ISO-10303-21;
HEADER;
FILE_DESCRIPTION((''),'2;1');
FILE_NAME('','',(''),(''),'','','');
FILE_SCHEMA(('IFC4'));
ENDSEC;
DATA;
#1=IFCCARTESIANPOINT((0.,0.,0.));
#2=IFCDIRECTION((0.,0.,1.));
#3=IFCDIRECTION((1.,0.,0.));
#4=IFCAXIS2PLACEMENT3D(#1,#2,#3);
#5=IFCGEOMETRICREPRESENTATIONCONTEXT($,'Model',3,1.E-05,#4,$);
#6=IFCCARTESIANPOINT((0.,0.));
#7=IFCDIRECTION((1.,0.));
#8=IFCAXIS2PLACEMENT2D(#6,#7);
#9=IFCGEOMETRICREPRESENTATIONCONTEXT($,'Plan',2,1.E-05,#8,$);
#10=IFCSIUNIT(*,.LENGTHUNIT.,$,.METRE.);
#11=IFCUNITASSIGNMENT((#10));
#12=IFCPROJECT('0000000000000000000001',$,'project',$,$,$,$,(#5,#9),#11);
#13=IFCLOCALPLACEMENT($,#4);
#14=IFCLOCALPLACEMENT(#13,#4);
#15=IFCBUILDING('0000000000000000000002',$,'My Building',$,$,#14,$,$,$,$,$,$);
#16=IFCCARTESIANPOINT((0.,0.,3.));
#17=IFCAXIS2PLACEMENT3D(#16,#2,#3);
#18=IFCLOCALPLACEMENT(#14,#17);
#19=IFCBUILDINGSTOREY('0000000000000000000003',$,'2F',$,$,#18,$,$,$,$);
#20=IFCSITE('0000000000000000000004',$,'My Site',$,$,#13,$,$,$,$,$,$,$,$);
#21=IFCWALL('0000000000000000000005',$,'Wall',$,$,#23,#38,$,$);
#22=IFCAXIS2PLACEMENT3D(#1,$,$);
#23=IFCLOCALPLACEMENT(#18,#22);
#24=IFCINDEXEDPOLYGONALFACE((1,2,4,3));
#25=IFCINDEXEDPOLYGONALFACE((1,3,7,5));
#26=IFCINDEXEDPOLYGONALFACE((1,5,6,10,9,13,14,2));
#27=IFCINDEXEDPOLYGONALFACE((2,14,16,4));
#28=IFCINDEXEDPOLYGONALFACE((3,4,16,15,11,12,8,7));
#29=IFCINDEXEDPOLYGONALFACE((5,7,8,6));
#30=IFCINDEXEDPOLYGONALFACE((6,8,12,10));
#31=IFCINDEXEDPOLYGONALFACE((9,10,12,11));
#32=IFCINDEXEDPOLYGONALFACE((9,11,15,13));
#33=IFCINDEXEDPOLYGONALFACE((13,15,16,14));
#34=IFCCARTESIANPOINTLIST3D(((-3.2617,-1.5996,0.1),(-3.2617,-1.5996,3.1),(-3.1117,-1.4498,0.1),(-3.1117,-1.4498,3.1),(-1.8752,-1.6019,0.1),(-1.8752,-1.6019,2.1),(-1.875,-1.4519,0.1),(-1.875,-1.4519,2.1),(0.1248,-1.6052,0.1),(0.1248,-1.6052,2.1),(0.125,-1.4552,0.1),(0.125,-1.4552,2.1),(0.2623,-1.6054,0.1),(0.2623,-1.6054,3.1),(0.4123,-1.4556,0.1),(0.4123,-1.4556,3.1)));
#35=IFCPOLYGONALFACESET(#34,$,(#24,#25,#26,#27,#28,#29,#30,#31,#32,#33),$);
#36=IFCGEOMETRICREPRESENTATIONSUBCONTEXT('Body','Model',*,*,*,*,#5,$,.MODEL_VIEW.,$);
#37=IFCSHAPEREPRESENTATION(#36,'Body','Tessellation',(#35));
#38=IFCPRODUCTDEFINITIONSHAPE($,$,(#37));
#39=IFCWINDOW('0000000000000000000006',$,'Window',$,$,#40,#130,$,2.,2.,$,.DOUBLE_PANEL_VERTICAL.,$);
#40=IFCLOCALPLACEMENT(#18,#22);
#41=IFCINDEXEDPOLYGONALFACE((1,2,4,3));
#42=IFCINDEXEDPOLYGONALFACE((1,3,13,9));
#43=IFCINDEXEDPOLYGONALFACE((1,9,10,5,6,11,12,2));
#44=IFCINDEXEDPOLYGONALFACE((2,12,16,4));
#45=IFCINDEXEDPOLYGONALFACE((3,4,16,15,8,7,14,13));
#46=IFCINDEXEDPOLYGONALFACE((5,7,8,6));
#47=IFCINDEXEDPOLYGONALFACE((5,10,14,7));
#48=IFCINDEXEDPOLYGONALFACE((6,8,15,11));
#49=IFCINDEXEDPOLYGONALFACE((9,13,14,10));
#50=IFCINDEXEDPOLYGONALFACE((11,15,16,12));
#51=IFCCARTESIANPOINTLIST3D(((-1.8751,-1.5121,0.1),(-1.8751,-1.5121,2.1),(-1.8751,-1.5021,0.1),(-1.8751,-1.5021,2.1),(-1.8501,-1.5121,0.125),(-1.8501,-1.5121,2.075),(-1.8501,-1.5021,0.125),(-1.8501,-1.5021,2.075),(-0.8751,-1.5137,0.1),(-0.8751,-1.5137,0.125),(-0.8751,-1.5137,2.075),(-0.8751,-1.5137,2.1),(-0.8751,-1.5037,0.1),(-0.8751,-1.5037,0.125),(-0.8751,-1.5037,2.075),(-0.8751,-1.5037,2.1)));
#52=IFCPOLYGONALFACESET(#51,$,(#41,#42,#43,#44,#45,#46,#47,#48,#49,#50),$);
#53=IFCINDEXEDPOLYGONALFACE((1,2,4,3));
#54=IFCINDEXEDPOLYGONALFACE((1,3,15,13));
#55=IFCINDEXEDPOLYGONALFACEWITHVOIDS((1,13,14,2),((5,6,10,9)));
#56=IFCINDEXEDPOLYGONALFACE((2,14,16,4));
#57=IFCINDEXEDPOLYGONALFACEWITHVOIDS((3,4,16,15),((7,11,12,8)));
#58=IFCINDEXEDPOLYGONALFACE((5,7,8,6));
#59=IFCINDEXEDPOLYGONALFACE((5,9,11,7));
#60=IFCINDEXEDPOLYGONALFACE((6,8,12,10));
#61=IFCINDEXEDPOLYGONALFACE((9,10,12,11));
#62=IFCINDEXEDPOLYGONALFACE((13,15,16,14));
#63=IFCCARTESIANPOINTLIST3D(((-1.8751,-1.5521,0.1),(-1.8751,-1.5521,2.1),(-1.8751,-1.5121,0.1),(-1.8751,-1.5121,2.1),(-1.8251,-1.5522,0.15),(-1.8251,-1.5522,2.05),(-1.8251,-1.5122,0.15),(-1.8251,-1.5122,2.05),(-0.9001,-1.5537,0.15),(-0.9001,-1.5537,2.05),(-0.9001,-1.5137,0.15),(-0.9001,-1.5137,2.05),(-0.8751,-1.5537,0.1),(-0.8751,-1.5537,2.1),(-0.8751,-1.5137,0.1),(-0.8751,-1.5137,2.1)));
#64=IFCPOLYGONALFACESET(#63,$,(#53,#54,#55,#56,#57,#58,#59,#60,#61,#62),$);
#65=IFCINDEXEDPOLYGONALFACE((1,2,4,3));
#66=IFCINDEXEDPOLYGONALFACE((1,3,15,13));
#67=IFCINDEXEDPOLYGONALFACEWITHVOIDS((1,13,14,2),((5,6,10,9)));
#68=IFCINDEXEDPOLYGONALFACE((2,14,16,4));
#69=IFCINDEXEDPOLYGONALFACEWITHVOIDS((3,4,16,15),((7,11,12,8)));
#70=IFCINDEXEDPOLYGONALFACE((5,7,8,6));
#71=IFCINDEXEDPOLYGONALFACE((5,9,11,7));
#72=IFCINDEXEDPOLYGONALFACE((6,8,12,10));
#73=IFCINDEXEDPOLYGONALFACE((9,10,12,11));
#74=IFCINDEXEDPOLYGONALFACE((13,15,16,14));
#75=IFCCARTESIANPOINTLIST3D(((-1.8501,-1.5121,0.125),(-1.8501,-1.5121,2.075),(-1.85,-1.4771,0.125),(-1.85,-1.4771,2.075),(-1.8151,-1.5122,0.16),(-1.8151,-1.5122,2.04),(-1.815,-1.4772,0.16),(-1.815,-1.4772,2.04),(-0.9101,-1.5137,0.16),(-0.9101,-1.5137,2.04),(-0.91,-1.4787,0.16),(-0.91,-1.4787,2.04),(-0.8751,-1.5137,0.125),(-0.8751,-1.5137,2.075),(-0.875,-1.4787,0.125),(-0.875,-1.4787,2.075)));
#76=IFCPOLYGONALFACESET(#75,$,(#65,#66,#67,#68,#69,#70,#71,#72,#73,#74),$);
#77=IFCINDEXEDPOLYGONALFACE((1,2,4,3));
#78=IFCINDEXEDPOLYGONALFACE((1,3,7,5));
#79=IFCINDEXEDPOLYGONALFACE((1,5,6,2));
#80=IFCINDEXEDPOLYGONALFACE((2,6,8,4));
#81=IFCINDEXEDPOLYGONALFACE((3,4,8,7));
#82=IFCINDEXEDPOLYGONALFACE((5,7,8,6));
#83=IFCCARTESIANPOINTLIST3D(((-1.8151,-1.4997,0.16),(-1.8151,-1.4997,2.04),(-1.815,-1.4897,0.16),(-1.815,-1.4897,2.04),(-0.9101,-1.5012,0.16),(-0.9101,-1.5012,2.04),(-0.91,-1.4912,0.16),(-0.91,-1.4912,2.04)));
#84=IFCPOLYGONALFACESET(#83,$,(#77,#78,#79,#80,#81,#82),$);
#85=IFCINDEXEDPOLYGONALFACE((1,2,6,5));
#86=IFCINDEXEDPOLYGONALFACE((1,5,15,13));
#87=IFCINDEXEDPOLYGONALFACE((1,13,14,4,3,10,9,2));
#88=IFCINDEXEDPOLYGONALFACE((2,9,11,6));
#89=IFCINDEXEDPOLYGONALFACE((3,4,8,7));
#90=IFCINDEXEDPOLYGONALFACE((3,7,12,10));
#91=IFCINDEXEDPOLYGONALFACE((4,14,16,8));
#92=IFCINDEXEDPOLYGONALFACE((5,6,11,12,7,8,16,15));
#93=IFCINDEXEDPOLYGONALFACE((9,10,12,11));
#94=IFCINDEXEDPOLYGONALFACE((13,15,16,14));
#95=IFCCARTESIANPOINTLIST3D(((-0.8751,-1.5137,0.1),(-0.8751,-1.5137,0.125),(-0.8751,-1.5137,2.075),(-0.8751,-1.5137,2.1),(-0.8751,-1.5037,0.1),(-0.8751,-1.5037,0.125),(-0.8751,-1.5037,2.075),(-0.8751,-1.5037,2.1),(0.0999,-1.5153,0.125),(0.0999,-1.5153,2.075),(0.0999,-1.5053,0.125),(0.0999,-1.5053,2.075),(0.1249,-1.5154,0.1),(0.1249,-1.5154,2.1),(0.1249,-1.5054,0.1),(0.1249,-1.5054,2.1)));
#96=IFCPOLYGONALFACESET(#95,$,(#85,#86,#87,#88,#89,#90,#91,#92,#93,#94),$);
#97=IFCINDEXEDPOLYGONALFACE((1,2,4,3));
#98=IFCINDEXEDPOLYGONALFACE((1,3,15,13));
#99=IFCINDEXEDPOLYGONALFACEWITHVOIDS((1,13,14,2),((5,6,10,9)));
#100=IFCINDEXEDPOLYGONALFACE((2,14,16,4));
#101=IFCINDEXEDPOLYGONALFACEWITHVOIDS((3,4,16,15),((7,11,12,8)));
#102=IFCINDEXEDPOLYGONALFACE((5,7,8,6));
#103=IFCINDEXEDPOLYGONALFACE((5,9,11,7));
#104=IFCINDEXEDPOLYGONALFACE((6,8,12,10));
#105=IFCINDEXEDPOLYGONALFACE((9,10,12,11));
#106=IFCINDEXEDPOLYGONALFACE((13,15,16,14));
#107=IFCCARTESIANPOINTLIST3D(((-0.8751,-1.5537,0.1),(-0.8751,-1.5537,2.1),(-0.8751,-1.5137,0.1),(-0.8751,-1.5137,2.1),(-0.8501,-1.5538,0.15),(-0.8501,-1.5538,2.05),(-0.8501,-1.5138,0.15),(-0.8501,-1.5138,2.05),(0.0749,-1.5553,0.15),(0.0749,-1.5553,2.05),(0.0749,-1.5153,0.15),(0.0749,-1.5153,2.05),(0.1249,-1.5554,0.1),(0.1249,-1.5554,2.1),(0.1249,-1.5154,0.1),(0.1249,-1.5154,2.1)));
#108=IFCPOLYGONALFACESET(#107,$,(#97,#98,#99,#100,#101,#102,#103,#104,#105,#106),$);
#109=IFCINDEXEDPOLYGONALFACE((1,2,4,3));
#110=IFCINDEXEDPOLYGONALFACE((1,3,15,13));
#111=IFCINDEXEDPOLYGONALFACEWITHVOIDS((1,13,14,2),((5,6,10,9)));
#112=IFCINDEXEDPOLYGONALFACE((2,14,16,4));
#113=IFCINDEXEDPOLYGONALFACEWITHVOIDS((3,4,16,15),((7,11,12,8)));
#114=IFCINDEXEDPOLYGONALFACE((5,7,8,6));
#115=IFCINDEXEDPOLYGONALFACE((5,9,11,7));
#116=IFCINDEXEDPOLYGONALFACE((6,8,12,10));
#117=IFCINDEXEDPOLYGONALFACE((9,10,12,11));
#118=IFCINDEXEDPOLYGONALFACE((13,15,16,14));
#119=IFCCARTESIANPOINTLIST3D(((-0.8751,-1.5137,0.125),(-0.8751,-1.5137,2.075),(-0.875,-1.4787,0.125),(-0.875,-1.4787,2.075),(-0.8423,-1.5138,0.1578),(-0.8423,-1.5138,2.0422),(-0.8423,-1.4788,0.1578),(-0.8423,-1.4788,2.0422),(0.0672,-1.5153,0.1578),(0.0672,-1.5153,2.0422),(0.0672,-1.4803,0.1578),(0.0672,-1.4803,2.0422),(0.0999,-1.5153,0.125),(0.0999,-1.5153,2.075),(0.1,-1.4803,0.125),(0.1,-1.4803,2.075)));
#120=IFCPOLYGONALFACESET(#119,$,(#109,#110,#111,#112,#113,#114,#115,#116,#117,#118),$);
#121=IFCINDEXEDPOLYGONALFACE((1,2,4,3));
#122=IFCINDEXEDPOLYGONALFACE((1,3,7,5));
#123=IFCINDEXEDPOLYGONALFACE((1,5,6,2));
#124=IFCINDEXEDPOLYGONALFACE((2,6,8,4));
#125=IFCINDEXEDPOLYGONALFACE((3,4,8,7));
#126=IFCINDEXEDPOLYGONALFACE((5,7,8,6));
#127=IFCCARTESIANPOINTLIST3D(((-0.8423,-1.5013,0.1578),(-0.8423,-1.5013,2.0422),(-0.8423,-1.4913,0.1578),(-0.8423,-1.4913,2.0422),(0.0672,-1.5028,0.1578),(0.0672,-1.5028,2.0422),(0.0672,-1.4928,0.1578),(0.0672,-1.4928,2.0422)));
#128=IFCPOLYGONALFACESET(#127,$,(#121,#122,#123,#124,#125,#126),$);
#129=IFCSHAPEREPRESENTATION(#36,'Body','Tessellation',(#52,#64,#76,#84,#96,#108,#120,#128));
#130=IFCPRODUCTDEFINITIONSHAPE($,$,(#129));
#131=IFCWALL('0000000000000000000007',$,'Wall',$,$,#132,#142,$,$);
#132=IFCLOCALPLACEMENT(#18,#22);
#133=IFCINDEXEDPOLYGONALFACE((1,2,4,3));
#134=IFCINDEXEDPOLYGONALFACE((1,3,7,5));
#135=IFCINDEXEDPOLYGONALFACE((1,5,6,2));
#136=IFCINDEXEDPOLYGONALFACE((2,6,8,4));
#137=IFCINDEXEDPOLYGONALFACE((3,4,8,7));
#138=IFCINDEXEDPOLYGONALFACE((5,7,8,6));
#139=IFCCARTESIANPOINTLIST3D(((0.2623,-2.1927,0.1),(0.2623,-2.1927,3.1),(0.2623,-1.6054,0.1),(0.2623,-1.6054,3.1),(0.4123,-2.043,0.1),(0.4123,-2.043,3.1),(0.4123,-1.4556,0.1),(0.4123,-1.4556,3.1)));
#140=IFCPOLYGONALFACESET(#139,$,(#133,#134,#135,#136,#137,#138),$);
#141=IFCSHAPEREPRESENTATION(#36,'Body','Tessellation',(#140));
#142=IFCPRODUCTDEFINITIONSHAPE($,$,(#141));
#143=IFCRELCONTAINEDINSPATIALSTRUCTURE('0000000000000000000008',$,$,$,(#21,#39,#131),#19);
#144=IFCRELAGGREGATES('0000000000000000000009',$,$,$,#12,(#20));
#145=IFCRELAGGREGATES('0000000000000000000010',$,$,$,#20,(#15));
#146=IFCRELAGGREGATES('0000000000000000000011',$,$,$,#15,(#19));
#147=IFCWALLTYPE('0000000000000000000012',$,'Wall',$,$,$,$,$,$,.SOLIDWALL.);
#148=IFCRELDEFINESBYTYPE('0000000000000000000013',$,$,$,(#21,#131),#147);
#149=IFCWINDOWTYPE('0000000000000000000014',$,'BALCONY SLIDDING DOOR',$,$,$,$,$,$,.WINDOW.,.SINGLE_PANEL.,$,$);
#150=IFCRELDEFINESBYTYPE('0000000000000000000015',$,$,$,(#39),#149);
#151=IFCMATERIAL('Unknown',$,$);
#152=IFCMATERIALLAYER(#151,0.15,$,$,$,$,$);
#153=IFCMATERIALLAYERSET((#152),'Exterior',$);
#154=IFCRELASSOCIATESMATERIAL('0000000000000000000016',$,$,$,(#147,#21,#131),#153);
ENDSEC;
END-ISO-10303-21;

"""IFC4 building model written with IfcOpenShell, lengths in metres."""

from ifc_helpers import new_model, entity, si_unit, frame, origin_with_axes, origin_2d_with_axis, place, context, subcontext, project, spatial, line, indexed_curve, outline, extrude, shape, source, transform, mapped, material, layer, layer_set, layer_usage, type_object, type_shapes, element, fill, save


model = new_model("IFC4")

# Units and contexts
model_context = context("Model", 3, precision=1e-05, world=origin_with_axes())
plan_context = context("Plan", 2, precision=1e-05, world=origin_2d_with_axis())
body_context_1 = subcontext(model_context, "Body", "Model", "MODEL_VIEW")
body_context_2 = subcontext(plan_context, "Body", "Plan", "PLAN_VIEW")
ifc_project = project(units=[si_unit("LENGTHUNIT", "METRE")], contexts=[model_context, plan_context])

# Site, building, storey
site_placement = place(None, origin_with_axes())
site = spatial("IfcSite", under=ifc_project, at=site_placement, Name="My Site")
building_placement = place(site_placement, origin_with_axes())
building = spatial("IfcBuilding", under=site, at=building_placement, Name="My Building")
storey_placement = place(building_placement, frame((0.0, 0.0, 3.0), z_axis=(0.0, 0.0, 1.0), x_axis=(1.0, 0.0, 0.0)))
storey = spatial("IfcBuildingStorey", under=building, at=storey_placement, Name="2F")

# Shared definitions
ifc_material = material(Name="Unknown")

# Shared definitions
ifc_layer_1 = layer(ifc_material, 0.15)
ifc_layer_set_1 = layer_set([ifc_layer_1], Name="Exterior")
wall_type_1 = type_object("IfcWallType", Name="Wall", PredefinedType="SOLIDWALL", material=ifc_layer_set_1)

# Wall, opening, window
ifc_layer_usage_1 = layer_usage(ifc_layer_set_1, "AXIS2", "POSITIVE", 0.0)
wall_1_placement = place(storey_placement, frame((-3.2617, -1.5996, 0.1), z_axis=(0.0, 0.0, 1.0), x_axis=(0.999999, -0.00165, 0.0)))
wall_1 = element("IfcWall", 1, at=wall_1_placement, inside=storey, type_object=wall_type_1, material=ifc_layer_usage_1, Name="Wall", context=body_context_1, shape_type="SweptSolid", body=[
    extrude(outline(indexed_curve([(0.0, 0.0), (0.1498, 0.15), (3.6737, 0.15), (3.5239, 0.0)], segments=[line(1, 2, 3, 4, 1)])), origin_with_axes(), (0.0, 0.0, 1.0), 3.0),
])
shared_shape_1 = source(origin_with_axes(), body_context_1, "Body", "SweptSolid", [
    extrude(outline(indexed_curve([(0.0, 0.0), (2.0, 0.0), (2.0, 2.0), (0.0, 2.0)], segments=[line(1, 2, 3, 4, 1)])), frame((0.0, -0.6, 0.0), z_axis=(0.0, -1.0, 0.0), x_axis=(1.0, 0.0, 0.0)), (0.0, 0.0, -1.0), 1.2),
])
opening_1_placement = place(wall_1_placement, frame((1.3864, -0.0002, 0.0), z_axis=(0.0, 0.0, 1.0), x_axis=(1.0, 0.0, 0.0)))
opening_1 = element("IfcOpeningElement", 2, at=opening_1_placement, cuts=wall_1, PredefinedType="OPENING", context=body_context_1, shape_type="MappedRepresentation", body=[
    mapped(shared_shape_1, transform((0.0, 0.0, 0.0), x_axis=(1.0, 0.0, 0.0), y_axis=(0.0, 1.0, 0.0), z_axis=(0.0, 0.0, 1.0), scale=1.0)),
])
window_type_1 = type_object("IfcWindowType", Name="BALCONY SLIDDING DOOR", PartitioningType="SINGLE_PANEL", PredefinedType="WINDOW")
shared_shape_2 = source(origin_with_axes(), body_context_1, "Body", "SweptSolid", [
    extrude(outline(indexed_curve([(1.0, 0.0), (0.0, 0.0), (0.0, 2.0), (1.0, 2.0), (1.0, 1.975), (0.025, 1.975), (0.025, 0.025), (1.0, 0.025)], segments=[line(1, 2, 3, 4, 5, 6, 7, 8, 1)])), frame((0.0, 0.09, 0.0), z_axis=(0.0, -1.0, 0.0), x_axis=(1.0, 0.0, 0.0)), (0.0, 0.0, -1.0), 0.01),
    extrude(outline(indexed_curve([(0.0, 0.0), (1.0, 0.0), (1.0, 2.0), (0.0, 2.0)], segments=[line(1, 2, 3, 4, 1)]), holes=[indexed_curve([(0.05, 0.05), (0.975, 0.05), (0.975, 1.95), (0.05, 1.95)], segments=[line(1, 2, 3, 4, 1)])]), frame((0.0, 0.05, 0.0), z_axis=(0.0, -1.0, 0.0), x_axis=(1.0, 0.0, 0.0)), (0.0, 0.0, -1.0), 0.04),
    extrude(outline(indexed_curve([(0.0, 0.0), (0.975, 0.0), (0.975, 1.95), (0.0, 1.95)], segments=[line(1, 2, 3, 4, 1)]), holes=[indexed_curve([(0.035, 0.035), (0.94, 0.035), (0.94, 1.915), (0.035, 1.915)], segments=[line(1, 2, 3, 4, 1)])]), frame((0.025, 0.09, 0.025), z_axis=(0.0, -1.0, 0.0), x_axis=(1.0, 0.0, 0.0)), (0.0, 0.0, -1.0), 0.035),
    extrude(outline(indexed_curve([(0.035, 0.035), (0.94, 0.035), (0.94, 1.915), (0.035, 1.915)], segments=[line(1, 2, 3, 4, 1)])), frame((0.025, 0.1025, 0.025), z_axis=(0.0, -1.0, 0.0), x_axis=(1.0, 0.0, 0.0)), (0.0, 0.0, -1.0), 0.01),
    extrude(outline(indexed_curve([(0.0, 2.0), (1.0, 2.0), (1.0, 0.0), (0.0, 0.0), (0.0, 0.025), (0.975, 0.025), (0.975, 1.975), (0.0, 1.975)], segments=[line(1, 2, 3, 4, 5, 6, 7, 8, 1)])), frame((1.0, 0.09, 0.0), z_axis=(0.0, -1.0, 0.0), x_axis=(1.0, 0.0, 0.0)), (0.0, 0.0, -1.0), 0.01),
    extrude(outline(indexed_curve([(0.0, 0.0), (1.0, 0.0), (1.0, 2.0), (0.0, 2.0)], segments=[line(1, 2, 3, 4, 1)]), holes=[indexed_curve([(0.025, 0.05), (0.95, 0.05), (0.95, 1.95), (0.025, 1.95)], segments=[line(1, 2, 3, 4, 1)])]), frame((1.0, 0.05, 0.0), z_axis=(0.0, -1.0, 0.0), x_axis=(1.0, 0.0, 0.0)), (0.0, 0.0, -1.0), 0.04),
    extrude(outline(indexed_curve([(0.0, 0.0), (0.975, 0.0), (0.975, 1.95), (0.0, 1.95)], segments=[line(1, 2, 3, 4, 1)]), holes=[indexed_curve([(0.0328, 0.0328), (0.9422, 0.0328), (0.9422, 1.9172), (0.0328, 1.9172)], segments=[line(1, 2, 3, 4, 1)])]), frame((1.0, 0.09, 0.025), z_axis=(0.0, -1.0, 0.0), x_axis=(1.0, 0.0, 0.0)), (0.0, 0.0, -1.0), 0.035),
    extrude(outline(indexed_curve([(0.0328, 0.0328), (0.9422, 0.0328), (0.9422, 1.9172), (0.0328, 1.9172)], segments=[line(1, 2, 3, 4, 1)])), frame((1.0, 0.1025, 0.025), z_axis=(0.0, -1.0, 0.0), x_axis=(1.0, 0.0, 0.0)), (0.0, 0.0, -1.0), 0.01),
])
shared_shape_3 = source(origin_with_axes(), body_context_2, "Body", "Curve2D", [
    entity("IfcIndexedPolyCurve", entity("IfcCartesianPointList2D", [[0.05, 0.05], [0.975, 0.05]])),
    entity("IfcIndexedPolyCurve", entity("IfcCartesianPointList2D", [[0.0, 0.1], [0.025, 0.1], [0.025, 0.09], [0.05, 0.09], [0.05, 0.05], [0.0, 0.05]]), [entity("IfcLineIndex", [1, 2, 3, 4, 5, 6, 1])]),
    entity("IfcIndexedPolyCurve", entity("IfcCartesianPointList2D", [[1.0, 0.1], [1.0, 0.1], [1.0, 0.09], [0.975, 0.09], [0.975, 0.05], [1.0, 0.05]])),
    entity("IfcIndexedPolyCurve", entity("IfcCartesianPointList2D", [[0.025, 0.09], [0.06, 0.09], [0.06, 0.125], [0.025, 0.125]]), [entity("IfcLineIndex", [1, 2, 3, 4, 1])]),
    entity("IfcIndexedPolyCurve", entity("IfcCartesianPointList2D", [[1.0, 0.09], [0.965, 0.09], [0.965, 0.125], [1.0, 0.125]]), [entity("IfcLineIndex", [1, 2, 3, 4, 1])]),
    entity("IfcIndexedPolyCurve", entity("IfcCartesianPointList2D", [[0.06, 0.09], [0.965, 0.09]])),
    entity("IfcIndexedPolyCurve", entity("IfcCartesianPointList2D", [[0.06, 0.125], [0.965, 0.125]])),
    entity("IfcIndexedPolyCurve", entity("IfcCartesianPointList2D", [[0.06, 0.1075], [0.965, 0.1075]])),
    entity("IfcIndexedPolyCurve", entity("IfcCartesianPointList2D", [[1.025, 0.05], [1.95, 0.05]])),
    entity("IfcIndexedPolyCurve", entity("IfcCartesianPointList2D", [[1.0, 0.1], [1.0, 0.1], [1.0, 0.09], [1.025, 0.09], [1.025, 0.05], [1.0, 0.05]])),
    entity("IfcIndexedPolyCurve", entity("IfcCartesianPointList2D", [[2.0, 0.1], [1.975, 0.1], [1.975, 0.09], [1.95, 0.09], [1.95, 0.05], [2.0, 0.05]]), [entity("IfcLineIndex", [1, 2, 3, 4, 5, 6, 1])]),
    entity("IfcIndexedPolyCurve", entity("IfcCartesianPointList2D", [[1.0, 0.09], [1.0328, 0.09], [1.0328, 0.125], [1.0, 0.125]]), [entity("IfcLineIndex", [1, 2, 3, 4, 1])]),
    entity("IfcIndexedPolyCurve", entity("IfcCartesianPointList2D", [[1.975, 0.09], [1.9422, 0.09], [1.9422, 0.125], [1.975, 0.125]]), [entity("IfcLineIndex", [1, 2, 3, 4, 1])]),
    entity("IfcIndexedPolyCurve", entity("IfcCartesianPointList2D", [[1.0328, 0.09], [1.9422, 0.09]])),
    entity("IfcIndexedPolyCurve", entity("IfcCartesianPointList2D", [[1.0328, 0.125], [1.9422, 0.125]])),
    entity("IfcIndexedPolyCurve", entity("IfcCartesianPointList2D", [[1.0328, 0.1075], [1.9422, 0.1075]])),
])
type_shapes(window_type_1, [shared_shape_2, shared_shape_3])
window_1_placement = place(opening_1_placement, frame((0.0, 0.0, 0.0), z_axis=(0.0, 0.0, 1.0), x_axis=(1.0, 0.0, 0.0)))
window_1 = element("IfcWindow", 3, at=window_1_placement, inside=storey, type_object=window_type_1, Name="Window", OverallHeight=2.0, OverallWidth=2.0, PartitioningType="DOUBLE_PANEL_VERTICAL", shapes=[
    shape(body_context_1, "Body", "MappedRepresentation", [mapped(shared_shape_2, transform((0.0, 0.0, 0.0), x_axis=(1.0, 0.0, 0.0), y_axis=(0.0, 1.0, 0.0), z_axis=(0.0, 0.0, 1.0), scale=1.0))]),
    shape(body_context_2, "Body", "MappedRepresentation", [mapped(shared_shape_3, transform((0.0, 0.0, 0.0), x_axis=(1.0, 0.0, 0.0), y_axis=(0.0, 1.0, 0.0), z_axis=(0.0, 0.0, 1.0), scale=1.0))]),
])
fill(opening_1, window_1)

# Wall
ifc_layer_usage_2 = layer_usage(ifc_layer_set_1, "AXIS2", "POSITIVE", 0.0)
wall_2_placement = place(storey_placement, frame((0.2623, -1.6054, 0.1), z_axis=(0.0, 0.0, 1.0), x_axis=(0.0, -1.0, 0.0)))
element("IfcWall", 4, at=wall_2_placement, inside=storey, type_object=wall_type_1, material=ifc_layer_usage_2, Name="Wall", context=body_context_1, shape_type="SweptSolid", body=[
    extrude(outline(indexed_curve([(0.0, 0.0), (-0.1498, 0.15), (0.4377, 0.15), (0.5873, 0.0)], segments=[line(1, 2, 3, 4, 1)])), origin_with_axes(), (0.0, 0.0, 1.0), 3.0),
])

save(model, "model.ifc")
